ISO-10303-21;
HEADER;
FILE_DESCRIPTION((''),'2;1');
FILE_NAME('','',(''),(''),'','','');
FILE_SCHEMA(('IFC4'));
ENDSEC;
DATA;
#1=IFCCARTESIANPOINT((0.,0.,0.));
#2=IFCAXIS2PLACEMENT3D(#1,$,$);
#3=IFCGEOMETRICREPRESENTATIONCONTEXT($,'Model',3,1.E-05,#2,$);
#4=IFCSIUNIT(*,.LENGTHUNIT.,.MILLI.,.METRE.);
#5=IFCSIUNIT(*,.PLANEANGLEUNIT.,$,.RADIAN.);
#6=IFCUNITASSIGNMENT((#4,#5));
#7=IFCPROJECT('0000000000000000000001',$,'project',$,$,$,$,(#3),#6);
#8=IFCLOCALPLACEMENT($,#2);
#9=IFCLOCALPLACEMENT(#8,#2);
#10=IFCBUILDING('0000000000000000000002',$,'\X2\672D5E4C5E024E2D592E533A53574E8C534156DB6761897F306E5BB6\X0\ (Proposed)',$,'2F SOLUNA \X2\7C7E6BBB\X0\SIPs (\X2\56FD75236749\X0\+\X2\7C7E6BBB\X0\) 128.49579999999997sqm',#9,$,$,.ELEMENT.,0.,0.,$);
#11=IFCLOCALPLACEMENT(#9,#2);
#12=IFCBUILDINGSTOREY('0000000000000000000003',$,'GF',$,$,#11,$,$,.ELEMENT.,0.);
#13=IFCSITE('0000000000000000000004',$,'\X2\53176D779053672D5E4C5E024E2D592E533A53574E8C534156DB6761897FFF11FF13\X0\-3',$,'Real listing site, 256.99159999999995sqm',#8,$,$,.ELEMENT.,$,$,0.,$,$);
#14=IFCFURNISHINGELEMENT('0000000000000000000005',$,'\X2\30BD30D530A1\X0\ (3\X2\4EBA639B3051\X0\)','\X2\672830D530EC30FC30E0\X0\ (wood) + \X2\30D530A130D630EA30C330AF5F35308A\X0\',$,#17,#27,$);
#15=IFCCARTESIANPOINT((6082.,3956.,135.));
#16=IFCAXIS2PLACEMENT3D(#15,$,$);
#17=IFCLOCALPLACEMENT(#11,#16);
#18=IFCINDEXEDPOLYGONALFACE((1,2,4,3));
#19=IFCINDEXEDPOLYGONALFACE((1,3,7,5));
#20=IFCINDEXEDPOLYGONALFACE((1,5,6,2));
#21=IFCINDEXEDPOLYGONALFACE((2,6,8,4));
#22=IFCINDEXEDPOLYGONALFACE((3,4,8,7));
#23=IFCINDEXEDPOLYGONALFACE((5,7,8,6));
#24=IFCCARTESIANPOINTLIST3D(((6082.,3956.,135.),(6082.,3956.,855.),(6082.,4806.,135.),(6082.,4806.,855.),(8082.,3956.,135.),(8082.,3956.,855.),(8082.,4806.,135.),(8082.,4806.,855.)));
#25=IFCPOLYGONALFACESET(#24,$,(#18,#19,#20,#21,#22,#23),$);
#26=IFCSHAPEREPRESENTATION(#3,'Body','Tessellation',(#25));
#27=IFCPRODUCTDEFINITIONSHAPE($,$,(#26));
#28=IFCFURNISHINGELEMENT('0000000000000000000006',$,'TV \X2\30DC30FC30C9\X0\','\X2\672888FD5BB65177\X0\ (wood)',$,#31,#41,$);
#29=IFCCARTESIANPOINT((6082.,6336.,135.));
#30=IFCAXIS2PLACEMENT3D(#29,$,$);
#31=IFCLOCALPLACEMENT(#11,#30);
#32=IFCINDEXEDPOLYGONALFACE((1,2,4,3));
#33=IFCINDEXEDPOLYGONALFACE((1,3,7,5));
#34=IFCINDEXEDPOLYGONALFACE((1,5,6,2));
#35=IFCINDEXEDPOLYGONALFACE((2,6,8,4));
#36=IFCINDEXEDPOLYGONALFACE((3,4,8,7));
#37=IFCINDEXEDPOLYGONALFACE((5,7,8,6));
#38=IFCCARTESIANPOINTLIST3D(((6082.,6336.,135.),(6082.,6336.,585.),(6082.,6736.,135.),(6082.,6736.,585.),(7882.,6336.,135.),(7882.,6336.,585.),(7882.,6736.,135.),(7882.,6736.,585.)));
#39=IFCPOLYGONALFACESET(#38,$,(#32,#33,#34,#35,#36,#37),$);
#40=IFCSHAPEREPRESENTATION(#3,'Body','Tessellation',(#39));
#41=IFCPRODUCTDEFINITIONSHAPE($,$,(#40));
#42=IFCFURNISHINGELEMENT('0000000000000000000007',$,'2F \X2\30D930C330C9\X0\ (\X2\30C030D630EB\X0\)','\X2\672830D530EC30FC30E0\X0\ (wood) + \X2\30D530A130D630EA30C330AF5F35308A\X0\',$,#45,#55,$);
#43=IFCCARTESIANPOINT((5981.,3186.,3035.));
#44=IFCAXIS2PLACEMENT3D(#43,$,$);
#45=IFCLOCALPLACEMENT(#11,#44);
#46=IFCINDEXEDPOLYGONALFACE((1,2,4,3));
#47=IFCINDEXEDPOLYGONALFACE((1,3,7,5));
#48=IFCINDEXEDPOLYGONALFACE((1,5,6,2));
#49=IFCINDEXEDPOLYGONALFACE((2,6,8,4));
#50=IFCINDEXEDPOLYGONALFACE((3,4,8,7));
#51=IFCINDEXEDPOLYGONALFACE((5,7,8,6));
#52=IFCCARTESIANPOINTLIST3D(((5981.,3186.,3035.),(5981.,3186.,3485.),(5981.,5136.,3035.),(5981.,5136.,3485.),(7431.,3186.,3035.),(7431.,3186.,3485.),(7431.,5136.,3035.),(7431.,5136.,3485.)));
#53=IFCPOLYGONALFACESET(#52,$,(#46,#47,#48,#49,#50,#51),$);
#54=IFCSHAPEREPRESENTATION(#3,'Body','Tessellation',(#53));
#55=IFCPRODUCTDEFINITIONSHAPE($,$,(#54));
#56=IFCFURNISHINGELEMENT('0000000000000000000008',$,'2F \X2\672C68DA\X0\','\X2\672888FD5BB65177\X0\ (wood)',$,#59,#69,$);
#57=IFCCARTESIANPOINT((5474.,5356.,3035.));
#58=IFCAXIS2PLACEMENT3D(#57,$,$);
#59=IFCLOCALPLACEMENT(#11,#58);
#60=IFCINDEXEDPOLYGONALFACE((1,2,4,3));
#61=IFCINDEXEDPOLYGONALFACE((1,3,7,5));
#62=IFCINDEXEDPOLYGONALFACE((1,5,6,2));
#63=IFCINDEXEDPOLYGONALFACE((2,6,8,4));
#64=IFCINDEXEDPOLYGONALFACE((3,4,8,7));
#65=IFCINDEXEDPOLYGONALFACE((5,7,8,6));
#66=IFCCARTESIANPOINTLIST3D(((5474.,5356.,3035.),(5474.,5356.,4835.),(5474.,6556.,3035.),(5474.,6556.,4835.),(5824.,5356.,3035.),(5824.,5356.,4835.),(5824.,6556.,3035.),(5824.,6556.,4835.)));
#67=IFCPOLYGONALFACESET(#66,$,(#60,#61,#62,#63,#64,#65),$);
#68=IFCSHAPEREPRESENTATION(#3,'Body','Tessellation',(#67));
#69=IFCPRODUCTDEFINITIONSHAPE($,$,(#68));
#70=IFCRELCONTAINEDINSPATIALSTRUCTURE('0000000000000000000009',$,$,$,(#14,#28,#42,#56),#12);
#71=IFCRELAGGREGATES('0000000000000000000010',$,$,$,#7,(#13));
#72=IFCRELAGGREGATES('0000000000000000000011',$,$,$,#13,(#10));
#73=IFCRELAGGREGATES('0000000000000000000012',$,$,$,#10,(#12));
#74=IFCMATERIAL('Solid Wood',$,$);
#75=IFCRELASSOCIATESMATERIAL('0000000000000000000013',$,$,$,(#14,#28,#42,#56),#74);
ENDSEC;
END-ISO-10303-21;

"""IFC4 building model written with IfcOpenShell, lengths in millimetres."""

from ifc_helpers import new_model, si_unit, frame, frame_2d, origin, place, context, project, spatial, rectangle, extrude, material, element, save


model = new_model("IFC4")

# Units and contexts
model_context = context("Model", 3, precision=1e-05, world=origin())
ifc_project = project(units=[si_unit("LENGTHUNIT", "METRE", prefix="MILLI"), si_unit("PLANEANGLEUNIT", "RADIAN")], contexts=[model_context])

# Site, building, storey
site_placement = place(None, origin())
site = spatial("IfcSite", under=ifc_project, at=site_placement, Name="北海道札幌市中央区南二十四条西１３-3", ObjectType="Real listing site, 256.99159999999995sqm", CompositionType="ELEMENT", RefElevation=0.0)
building_placement = place(site_placement, origin())
building = spatial("IfcBuilding", under=site, at=building_placement, Name="札幌市中央区南二十四条西の家 (Proposed)", ObjectType="2F SOLUNA 籾殻SIPs (国産杉+籾殻) 128.49579999999997sqm", CompositionType="ELEMENT", ElevationOfRefHeight=0.0, ElevationOfTerrain=0.0)
storey_placement = place(building_placement, origin())
storey = spatial("IfcBuildingStorey", under=building, at=storey_placement, Name="GF", CompositionType="ELEMENT", Elevation=0.0)

# Shared definitions
ifc_material_1 = material(Name="Solid Wood")

# Furnishing elements
furnishing_1_placement = place(storey_placement, frame((6082.0, 3956.0, 135.0)))
element("IfcFurnishingElement", 1, at=furnishing_1_placement, inside=storey, material=ifc_material_1, Name="ソファ (3人掛け)", Description="木フレーム (wood) + ファブリック張り", context=model_context, shape_type="SweptSolid", body=[
    extrude(rectangle(XDim=2000.0, YDim=850.0, at=frame_2d((1000.0, 425.0))), frame((6082.0, 3956.0, 135.0)), (0.0, 0.0, 1.0), 720.0),
])
furnishing_2_placement = place(storey_placement, frame((6082.0, 6336.0, 135.0)))
element("IfcFurnishingElement", 2, at=furnishing_2_placement, inside=storey, material=ifc_material_1, Name="TV ボード", Description="木製家具 (wood)", context=model_context, shape_type="SweptSolid", body=[
    extrude(rectangle(XDim=1800.0, YDim=400.0, at=frame_2d((900.0, 200.0))), frame((6082.0, 6336.0, 135.0)), (0.0, 0.0, 1.0), 450.0),
])
furnishing_3_placement = place(storey_placement, frame((5981.0, 3186.0, 3035.0)))
element("IfcFurnishingElement", 3, at=furnishing_3_placement, inside=storey, material=ifc_material_1, Name="2F ベッド (ダブル)", Description="木フレーム (wood) + ファブリック張り", context=model_context, shape_type="SweptSolid", body=[
    extrude(rectangle(XDim=1450.0, YDim=1950.0, at=frame_2d((725.0, 975.0))), frame((5981.0, 3186.0, 3035.0)), (0.0, 0.0, 1.0), 450.0),
])
furnishing_4_placement = place(storey_placement, frame((5474.0, 5356.0, 3035.0)))
element("IfcFurnishingElement", 4, at=furnishing_4_placement, inside=storey, material=ifc_material_1, Name="2F 本棚", Description="木製家具 (wood)", context=model_context, shape_type="SweptSolid", body=[
    extrude(rectangle(XDim=350.0, YDim=1200.0, at=frame_2d((175.0, 600.0))), frame((5474.0, 5356.0, 3035.0)), (0.0, 0.0, 1.0), 1800.0),
])

save(model, "model.ifc")
